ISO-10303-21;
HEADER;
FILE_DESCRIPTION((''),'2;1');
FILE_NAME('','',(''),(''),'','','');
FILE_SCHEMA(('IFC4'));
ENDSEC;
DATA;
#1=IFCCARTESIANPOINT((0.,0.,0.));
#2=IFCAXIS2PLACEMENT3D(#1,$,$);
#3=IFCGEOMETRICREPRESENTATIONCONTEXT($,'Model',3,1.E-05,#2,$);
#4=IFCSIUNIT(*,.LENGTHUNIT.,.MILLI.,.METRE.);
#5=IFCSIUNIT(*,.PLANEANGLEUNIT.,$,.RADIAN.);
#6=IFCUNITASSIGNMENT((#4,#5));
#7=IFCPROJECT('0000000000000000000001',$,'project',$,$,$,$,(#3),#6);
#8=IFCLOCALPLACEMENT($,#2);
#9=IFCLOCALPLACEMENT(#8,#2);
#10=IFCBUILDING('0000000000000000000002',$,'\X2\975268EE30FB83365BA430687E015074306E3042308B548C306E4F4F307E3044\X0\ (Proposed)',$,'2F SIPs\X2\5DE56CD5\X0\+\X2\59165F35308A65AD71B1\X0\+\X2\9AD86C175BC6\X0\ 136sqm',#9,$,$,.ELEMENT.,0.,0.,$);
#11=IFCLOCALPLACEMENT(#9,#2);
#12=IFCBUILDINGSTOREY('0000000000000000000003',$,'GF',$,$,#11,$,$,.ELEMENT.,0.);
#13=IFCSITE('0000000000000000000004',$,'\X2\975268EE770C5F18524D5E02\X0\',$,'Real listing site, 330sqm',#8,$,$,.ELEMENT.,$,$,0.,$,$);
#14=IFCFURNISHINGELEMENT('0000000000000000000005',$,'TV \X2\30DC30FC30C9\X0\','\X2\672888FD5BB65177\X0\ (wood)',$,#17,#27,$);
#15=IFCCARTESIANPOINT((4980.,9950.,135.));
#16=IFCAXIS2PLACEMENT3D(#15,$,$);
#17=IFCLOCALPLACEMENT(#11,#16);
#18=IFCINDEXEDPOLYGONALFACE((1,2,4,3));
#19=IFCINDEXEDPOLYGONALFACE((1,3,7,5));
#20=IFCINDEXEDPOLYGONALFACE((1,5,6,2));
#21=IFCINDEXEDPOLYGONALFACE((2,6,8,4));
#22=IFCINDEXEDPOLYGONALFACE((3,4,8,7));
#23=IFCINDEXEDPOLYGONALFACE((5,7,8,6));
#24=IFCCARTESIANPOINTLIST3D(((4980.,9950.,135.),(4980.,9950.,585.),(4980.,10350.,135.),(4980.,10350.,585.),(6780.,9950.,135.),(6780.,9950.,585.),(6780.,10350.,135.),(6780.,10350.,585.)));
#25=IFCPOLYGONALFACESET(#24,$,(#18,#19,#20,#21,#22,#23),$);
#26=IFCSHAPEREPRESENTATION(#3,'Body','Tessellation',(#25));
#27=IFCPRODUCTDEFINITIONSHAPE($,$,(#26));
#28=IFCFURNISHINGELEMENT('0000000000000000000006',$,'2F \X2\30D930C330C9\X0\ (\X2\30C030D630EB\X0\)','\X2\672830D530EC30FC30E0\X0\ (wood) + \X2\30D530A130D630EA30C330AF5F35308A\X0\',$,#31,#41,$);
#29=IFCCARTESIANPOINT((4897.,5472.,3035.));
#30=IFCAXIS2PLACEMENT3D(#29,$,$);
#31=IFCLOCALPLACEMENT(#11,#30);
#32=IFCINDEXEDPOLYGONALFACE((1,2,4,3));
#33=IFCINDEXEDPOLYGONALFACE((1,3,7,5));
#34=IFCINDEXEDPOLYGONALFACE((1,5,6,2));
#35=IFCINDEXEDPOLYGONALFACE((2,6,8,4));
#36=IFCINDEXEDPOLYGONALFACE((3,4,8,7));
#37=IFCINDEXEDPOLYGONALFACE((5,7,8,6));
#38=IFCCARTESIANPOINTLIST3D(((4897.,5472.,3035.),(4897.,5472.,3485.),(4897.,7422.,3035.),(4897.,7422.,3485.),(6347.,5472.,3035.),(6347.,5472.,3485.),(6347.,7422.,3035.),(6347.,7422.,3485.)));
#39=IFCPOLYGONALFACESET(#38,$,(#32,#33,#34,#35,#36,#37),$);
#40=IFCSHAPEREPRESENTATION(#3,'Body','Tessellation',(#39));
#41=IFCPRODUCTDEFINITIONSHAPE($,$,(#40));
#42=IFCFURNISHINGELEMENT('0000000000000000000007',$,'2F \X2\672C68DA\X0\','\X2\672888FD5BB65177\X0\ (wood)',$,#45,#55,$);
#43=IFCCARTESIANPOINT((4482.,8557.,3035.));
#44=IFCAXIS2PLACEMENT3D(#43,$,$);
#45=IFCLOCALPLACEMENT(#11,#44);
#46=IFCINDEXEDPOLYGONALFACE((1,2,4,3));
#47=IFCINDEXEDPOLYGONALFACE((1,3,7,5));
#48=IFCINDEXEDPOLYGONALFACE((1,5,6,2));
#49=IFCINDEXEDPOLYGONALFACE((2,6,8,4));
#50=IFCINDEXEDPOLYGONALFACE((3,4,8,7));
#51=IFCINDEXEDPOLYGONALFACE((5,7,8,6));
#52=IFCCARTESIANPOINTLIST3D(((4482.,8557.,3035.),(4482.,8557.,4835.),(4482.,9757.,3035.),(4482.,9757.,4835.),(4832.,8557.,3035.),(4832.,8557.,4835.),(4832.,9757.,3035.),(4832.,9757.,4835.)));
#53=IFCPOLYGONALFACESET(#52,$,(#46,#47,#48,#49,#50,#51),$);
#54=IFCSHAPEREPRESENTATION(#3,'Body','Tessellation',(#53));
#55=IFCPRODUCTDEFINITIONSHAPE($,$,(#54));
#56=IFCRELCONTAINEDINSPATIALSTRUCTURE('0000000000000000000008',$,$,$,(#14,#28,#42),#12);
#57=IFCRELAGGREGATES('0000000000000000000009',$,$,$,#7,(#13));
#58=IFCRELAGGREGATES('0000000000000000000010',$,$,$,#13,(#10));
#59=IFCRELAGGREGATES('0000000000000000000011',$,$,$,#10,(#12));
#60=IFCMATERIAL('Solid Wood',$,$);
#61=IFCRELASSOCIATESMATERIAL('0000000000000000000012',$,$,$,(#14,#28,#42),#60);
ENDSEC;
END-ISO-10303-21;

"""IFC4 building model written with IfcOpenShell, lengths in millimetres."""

from ifc_helpers import new_model, si_unit, frame, frame_2d, origin, place, context, project, spatial, rectangle, extrude, material, element, save


model = new_model("IFC4")

# Units and contexts
model_context = context("Model", 3, precision=1e-05, world=origin())
ifc_project = project(units=[si_unit("LENGTHUNIT", "METRE", prefix="MILLI"), si_unit("PLANEANGLEUNIT", "RADIAN")], contexts=[model_context])

# Site, building, storey
site_placement = place(None, origin())
site = spatial("IfcSite", under=ifc_project, at=site_placement, Name="青森県弘前市", ObjectType="Real listing site, 330sqm", CompositionType="ELEMENT", RefElevation=0.0)
building_placement = place(site_placement, origin())
building = spatial("IfcBuilding", under=site, at=building_placement, Name="青森・茶室と縁側のある和の住まい (Proposed)", ObjectType="2F SIPs工法+外張り断熱+高気密 136sqm", CompositionType="ELEMENT", ElevationOfRefHeight=0.0, ElevationOfTerrain=0.0)
storey_placement = place(building_placement, origin())
storey = spatial("IfcBuildingStorey", under=building, at=storey_placement, Name="GF", CompositionType="ELEMENT", Elevation=0.0)

# Shared definitions
ifc_material_1 = material(Name="Solid Wood")

# Furnishing elements
furnishing_1_placement = place(storey_placement, frame((4980.0, 9950.0, 135.0)))
element("IfcFurnishingElement", 1, at=furnishing_1_placement, inside=storey, material=ifc_material_1, Name="TV ボード", Description="木製家具 (wood)", context=model_context, shape_type="SweptSolid", body=[
    extrude(rectangle(XDim=1800.0, YDim=400.0, at=frame_2d((900.0, 200.0))), frame((4980.0, 9950.0, 135.0)), (0.0, 0.0, 1.0), 450.0),
])
furnishing_2_placement = place(storey_placement, frame((4897.0, 5472.0, 3035.0)))
element("IfcFurnishingElement", 2, at=furnishing_2_placement, inside=storey, material=ifc_material_1, Name="2F ベッド (ダブル)", Description="木フレーム (wood) + ファブリック張り", context=model_context, shape_type="SweptSolid", body=[
    extrude(rectangle(XDim=1450.0, YDim=1950.0, at=frame_2d((725.0, 975.0))), frame((4897.0, 5472.0, 3035.0)), (0.0, 0.0, 1.0), 450.0),
])
furnishing_3_placement = place(storey_placement, frame((4482.0, 8557.0, 3035.0)))
element("IfcFurnishingElement", 3, at=furnishing_3_placement, inside=storey, material=ifc_material_1, Name="2F 本棚", Description="木製家具 (wood)", context=model_context, shape_type="SweptSolid", body=[
    extrude(rectangle(XDim=350.0, YDim=1200.0, at=frame_2d((175.0, 600.0))), frame((4482.0, 8557.0, 3035.0)), (0.0, 0.0, 1.0), 1800.0),
])

save(model, "model.ifc")
